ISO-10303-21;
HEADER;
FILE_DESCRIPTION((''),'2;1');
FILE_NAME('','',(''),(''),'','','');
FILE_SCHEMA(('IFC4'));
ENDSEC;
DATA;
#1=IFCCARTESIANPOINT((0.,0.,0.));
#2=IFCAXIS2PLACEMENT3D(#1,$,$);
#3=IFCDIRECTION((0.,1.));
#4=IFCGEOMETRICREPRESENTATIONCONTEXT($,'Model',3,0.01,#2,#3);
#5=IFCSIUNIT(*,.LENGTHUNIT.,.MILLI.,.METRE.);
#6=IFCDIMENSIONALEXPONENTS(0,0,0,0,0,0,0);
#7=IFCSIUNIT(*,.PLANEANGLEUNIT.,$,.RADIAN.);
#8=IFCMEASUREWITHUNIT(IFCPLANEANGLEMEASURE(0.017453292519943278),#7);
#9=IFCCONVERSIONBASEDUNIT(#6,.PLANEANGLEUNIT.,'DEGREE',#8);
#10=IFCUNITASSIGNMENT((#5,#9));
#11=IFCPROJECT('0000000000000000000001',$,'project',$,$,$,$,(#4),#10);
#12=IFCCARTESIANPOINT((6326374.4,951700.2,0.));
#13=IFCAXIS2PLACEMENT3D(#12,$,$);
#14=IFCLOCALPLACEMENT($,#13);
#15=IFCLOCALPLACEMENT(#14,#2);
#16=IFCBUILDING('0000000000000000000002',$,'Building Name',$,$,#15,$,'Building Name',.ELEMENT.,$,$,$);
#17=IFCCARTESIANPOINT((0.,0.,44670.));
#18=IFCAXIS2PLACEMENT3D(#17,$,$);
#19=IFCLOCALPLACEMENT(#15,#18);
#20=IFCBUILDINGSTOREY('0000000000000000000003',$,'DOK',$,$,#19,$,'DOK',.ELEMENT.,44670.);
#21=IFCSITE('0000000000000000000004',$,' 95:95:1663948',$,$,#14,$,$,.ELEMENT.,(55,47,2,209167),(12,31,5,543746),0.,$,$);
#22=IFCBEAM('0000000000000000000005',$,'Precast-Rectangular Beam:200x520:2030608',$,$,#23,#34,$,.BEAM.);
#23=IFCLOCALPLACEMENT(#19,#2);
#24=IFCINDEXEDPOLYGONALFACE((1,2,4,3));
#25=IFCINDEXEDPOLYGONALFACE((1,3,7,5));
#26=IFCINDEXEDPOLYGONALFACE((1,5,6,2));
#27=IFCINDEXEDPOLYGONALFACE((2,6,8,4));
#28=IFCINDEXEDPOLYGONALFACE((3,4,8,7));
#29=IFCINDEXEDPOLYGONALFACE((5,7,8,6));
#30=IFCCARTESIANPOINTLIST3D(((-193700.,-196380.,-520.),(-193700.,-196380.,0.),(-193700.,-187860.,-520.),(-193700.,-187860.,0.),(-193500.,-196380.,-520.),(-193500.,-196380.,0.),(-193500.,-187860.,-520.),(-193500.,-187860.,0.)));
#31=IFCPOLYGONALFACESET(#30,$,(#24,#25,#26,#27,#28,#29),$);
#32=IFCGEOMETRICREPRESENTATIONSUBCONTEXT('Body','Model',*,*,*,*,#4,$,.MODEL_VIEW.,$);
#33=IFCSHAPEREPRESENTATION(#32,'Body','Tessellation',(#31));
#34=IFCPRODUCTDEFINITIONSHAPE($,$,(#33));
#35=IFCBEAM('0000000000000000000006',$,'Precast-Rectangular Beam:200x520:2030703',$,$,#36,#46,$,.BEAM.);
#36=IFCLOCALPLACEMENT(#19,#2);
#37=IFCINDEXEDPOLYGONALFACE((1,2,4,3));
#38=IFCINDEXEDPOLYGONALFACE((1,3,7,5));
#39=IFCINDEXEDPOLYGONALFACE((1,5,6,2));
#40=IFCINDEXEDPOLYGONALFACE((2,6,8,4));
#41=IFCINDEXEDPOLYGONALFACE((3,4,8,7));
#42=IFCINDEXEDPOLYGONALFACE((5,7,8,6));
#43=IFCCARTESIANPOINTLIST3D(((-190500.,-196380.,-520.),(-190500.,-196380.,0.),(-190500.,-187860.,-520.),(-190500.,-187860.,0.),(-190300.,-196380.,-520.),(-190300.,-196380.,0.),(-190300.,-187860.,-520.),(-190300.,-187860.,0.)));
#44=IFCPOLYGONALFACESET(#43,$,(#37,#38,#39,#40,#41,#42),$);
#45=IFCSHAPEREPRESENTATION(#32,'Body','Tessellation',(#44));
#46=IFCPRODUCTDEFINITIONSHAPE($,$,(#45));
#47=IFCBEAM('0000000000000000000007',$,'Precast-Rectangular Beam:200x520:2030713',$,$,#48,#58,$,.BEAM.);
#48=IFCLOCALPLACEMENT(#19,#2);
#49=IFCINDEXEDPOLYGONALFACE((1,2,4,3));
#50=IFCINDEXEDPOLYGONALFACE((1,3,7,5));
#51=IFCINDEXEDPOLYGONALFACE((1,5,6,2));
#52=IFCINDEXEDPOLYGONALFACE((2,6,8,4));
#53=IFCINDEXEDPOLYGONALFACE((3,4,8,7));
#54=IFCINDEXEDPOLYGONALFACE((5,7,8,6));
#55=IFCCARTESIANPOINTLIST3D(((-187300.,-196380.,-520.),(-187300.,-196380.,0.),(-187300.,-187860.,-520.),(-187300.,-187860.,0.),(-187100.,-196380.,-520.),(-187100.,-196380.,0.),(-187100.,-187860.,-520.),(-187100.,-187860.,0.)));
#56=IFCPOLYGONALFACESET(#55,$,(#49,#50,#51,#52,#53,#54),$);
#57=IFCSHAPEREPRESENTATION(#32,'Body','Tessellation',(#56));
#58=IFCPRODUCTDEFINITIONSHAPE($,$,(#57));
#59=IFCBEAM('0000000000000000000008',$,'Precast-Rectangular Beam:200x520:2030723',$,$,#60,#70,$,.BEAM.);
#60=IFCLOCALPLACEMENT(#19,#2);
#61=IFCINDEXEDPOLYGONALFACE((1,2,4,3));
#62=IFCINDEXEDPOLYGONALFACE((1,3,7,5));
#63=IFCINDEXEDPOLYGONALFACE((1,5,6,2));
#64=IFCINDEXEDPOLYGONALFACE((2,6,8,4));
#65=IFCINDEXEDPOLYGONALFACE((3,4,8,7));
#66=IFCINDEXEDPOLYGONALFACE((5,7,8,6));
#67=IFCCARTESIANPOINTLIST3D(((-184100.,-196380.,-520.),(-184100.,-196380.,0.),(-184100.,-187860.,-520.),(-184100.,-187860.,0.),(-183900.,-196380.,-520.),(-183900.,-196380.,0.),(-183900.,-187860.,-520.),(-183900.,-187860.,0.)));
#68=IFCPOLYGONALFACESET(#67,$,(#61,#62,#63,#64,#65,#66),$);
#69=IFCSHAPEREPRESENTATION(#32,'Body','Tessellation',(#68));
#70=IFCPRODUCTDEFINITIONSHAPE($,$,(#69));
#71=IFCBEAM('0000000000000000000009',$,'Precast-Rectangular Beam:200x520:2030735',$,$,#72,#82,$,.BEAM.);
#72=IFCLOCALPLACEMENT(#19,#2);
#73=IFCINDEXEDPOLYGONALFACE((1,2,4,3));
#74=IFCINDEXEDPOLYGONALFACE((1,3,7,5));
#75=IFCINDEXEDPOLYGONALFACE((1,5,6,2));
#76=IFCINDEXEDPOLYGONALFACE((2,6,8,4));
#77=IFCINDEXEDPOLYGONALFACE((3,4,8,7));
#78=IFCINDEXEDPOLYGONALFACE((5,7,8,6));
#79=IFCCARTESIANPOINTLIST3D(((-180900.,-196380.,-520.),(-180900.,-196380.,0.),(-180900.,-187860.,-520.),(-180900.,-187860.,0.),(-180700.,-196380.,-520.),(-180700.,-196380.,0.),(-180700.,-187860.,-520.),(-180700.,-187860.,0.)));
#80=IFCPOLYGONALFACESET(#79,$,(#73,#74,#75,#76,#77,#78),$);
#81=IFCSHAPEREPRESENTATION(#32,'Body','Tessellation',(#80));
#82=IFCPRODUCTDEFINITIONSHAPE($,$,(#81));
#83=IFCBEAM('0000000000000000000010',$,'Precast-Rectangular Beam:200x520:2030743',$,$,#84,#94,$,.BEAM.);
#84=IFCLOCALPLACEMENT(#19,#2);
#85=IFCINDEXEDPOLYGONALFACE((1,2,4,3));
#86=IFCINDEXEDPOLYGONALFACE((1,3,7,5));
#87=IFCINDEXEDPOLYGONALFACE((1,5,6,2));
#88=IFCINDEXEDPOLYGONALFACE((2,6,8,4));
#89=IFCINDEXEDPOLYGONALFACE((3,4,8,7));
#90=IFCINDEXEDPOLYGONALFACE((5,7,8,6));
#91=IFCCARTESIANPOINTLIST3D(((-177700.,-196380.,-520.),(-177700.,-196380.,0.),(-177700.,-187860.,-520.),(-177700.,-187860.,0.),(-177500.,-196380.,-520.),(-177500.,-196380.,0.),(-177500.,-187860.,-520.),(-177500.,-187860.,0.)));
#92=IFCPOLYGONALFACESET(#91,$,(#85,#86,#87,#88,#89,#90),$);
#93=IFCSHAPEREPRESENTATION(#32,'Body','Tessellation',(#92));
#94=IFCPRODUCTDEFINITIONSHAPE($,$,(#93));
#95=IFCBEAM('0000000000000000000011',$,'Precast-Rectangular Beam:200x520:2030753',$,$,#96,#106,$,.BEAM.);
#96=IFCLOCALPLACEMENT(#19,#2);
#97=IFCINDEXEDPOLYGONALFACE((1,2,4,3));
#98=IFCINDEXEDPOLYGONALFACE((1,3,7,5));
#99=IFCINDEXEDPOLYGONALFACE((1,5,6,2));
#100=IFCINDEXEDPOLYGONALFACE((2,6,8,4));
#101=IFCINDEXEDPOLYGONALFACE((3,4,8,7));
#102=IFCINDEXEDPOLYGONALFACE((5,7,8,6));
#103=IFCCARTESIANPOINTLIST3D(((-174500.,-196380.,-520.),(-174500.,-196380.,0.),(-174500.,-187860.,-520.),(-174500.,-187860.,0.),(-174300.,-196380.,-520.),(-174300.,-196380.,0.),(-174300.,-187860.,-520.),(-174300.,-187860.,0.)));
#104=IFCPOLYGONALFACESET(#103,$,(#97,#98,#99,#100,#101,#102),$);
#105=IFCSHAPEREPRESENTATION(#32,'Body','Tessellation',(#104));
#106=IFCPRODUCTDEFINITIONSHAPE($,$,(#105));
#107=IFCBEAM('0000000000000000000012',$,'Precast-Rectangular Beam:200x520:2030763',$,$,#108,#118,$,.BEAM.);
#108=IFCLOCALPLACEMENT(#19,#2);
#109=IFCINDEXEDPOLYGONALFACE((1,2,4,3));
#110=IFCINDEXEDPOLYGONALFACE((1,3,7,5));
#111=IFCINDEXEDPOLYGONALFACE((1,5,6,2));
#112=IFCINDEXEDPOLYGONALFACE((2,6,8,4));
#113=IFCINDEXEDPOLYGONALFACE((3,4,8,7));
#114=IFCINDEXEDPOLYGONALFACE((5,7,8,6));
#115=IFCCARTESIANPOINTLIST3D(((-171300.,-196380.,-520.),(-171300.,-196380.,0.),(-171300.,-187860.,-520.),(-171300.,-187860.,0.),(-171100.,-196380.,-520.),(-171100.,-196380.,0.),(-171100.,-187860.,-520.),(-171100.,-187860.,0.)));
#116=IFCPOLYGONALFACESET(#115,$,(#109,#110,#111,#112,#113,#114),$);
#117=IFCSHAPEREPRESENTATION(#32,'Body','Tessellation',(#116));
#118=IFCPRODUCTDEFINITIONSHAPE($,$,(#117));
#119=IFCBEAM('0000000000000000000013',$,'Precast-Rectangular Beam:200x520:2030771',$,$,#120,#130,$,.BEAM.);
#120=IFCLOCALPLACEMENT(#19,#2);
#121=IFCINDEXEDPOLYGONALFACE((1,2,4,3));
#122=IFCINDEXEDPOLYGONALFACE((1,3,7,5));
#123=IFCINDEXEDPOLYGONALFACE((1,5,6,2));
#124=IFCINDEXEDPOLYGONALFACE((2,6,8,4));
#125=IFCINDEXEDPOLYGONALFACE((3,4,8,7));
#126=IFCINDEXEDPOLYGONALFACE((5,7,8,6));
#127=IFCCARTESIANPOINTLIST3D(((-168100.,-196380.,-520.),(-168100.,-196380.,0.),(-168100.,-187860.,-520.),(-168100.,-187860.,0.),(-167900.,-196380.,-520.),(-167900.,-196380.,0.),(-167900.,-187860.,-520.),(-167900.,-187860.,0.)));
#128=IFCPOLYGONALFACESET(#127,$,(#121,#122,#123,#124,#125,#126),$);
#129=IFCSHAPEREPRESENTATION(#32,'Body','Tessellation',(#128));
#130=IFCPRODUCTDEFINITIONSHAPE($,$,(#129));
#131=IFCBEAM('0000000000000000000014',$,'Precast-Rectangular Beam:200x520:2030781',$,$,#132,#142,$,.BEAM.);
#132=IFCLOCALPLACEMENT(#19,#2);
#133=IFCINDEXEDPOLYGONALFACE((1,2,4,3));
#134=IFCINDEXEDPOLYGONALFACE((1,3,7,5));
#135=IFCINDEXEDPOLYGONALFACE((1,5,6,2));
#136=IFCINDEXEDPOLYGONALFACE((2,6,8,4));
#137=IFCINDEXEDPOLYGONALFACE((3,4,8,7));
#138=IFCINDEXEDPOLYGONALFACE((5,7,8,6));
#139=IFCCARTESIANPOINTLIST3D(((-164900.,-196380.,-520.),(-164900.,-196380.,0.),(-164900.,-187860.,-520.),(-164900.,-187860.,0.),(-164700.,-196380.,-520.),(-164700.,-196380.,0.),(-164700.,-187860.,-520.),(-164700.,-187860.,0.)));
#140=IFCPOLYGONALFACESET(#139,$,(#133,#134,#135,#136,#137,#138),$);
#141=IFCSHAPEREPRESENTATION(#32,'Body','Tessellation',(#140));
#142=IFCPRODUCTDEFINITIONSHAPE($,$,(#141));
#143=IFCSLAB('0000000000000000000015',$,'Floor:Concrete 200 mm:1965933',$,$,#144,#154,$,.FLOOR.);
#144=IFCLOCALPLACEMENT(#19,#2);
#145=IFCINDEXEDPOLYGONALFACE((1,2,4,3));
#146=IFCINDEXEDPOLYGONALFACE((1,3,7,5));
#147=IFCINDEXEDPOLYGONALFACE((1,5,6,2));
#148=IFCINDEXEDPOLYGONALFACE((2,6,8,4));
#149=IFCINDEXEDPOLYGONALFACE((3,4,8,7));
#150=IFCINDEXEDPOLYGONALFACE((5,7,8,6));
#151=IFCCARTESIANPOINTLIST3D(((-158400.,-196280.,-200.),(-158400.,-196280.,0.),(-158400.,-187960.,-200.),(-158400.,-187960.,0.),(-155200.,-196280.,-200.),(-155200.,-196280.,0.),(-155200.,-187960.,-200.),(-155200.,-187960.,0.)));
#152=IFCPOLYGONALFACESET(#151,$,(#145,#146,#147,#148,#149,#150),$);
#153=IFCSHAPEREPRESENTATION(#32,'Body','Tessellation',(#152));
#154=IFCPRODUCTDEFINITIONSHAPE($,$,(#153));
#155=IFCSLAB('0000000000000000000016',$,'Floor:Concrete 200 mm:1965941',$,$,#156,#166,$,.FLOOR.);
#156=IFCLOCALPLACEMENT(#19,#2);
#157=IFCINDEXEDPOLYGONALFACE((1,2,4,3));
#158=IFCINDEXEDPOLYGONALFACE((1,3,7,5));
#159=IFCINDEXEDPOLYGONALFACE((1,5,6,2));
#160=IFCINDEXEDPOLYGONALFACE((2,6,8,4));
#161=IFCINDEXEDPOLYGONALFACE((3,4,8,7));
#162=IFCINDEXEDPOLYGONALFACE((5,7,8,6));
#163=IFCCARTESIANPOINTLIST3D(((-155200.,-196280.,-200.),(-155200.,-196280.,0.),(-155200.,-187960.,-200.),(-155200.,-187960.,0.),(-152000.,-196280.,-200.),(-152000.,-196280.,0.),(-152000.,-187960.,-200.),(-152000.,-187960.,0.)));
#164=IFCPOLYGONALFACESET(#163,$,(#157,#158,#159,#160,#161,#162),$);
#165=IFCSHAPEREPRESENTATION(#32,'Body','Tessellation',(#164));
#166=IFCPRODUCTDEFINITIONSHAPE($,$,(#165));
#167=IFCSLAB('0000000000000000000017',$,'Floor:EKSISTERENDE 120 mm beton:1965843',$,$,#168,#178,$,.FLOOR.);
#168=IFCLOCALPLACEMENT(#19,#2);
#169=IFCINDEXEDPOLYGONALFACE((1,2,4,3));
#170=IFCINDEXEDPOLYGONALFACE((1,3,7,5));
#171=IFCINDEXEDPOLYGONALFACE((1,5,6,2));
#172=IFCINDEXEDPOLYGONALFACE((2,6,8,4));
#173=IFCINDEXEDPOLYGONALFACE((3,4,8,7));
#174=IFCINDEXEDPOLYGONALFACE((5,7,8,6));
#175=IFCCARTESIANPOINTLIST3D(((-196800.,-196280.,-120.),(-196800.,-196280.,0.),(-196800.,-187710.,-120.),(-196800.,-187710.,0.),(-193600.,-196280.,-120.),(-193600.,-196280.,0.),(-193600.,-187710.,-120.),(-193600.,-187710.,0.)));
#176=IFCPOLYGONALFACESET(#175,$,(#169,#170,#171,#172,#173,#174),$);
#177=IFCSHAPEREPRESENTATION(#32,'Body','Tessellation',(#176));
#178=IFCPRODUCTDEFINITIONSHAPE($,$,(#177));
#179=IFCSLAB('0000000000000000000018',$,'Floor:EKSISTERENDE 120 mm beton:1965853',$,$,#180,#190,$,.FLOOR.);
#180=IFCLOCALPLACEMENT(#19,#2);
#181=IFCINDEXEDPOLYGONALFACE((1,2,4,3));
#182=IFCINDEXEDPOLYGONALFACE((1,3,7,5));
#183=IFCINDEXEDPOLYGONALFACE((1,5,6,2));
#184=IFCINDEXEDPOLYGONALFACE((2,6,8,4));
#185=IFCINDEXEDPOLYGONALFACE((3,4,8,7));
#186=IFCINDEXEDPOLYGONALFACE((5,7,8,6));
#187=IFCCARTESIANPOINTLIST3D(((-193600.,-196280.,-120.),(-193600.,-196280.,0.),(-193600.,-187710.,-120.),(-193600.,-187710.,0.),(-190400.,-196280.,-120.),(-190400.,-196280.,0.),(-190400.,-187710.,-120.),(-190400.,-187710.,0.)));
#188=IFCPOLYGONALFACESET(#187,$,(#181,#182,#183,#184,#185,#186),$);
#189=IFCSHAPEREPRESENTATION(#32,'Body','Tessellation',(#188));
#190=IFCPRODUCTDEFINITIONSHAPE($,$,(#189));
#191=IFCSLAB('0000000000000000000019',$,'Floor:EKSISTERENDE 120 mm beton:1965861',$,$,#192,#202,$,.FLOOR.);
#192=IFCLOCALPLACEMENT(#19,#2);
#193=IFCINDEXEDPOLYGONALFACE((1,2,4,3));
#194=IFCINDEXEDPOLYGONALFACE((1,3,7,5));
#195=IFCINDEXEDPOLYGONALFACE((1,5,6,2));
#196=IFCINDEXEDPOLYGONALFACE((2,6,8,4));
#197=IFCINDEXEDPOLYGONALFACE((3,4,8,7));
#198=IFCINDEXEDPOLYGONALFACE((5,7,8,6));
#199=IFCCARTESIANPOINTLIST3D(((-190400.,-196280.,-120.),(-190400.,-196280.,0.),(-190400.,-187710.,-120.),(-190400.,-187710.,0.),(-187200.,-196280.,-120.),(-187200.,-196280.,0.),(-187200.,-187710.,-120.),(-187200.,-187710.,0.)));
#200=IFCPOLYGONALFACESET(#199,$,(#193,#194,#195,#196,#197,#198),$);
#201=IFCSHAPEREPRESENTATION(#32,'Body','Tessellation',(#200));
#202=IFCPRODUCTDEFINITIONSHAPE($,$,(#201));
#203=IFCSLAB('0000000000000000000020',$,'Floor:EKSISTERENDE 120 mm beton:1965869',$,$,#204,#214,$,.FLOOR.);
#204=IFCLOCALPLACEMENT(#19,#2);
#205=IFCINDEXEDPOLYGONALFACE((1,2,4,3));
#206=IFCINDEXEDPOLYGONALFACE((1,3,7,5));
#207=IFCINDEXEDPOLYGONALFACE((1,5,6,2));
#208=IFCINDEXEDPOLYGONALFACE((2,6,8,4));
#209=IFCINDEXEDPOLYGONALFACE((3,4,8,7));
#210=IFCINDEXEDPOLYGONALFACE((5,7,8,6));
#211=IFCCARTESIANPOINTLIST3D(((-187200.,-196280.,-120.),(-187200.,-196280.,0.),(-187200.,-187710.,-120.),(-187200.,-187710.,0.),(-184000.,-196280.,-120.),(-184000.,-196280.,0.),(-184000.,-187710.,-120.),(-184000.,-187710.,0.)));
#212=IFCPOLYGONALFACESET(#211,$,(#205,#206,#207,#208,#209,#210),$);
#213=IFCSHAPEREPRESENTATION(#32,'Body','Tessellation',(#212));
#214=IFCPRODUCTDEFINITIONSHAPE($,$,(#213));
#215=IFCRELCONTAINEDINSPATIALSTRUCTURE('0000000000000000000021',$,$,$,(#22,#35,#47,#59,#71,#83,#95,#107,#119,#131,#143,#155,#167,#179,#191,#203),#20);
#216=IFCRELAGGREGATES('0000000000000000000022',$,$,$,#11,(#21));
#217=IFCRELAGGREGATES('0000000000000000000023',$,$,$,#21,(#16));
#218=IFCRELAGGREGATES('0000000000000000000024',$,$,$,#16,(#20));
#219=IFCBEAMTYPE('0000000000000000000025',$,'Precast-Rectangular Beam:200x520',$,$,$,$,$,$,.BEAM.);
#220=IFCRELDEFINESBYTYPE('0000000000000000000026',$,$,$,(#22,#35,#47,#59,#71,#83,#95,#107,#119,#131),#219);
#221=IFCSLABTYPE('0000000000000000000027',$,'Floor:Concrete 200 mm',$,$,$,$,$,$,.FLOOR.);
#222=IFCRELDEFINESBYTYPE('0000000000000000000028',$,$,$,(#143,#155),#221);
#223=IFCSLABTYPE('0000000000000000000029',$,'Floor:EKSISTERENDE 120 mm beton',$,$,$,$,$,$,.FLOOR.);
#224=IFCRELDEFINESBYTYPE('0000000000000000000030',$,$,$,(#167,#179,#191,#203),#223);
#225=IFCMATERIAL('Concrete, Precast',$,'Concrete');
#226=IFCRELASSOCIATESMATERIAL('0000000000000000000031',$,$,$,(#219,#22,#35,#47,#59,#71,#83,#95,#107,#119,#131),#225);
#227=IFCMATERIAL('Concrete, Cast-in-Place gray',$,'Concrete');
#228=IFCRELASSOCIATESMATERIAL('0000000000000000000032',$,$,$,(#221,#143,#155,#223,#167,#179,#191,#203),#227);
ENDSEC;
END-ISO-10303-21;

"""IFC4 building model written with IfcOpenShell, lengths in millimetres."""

from ifc_helpers import new_model, entity, si_unit, converted_unit, direction, frame, origin, place, context, subcontext, project, spatial, indexed_curve, outline, extrude, source, transform, mapped, material, type_object, type_shapes, element, save


model = new_model("IFC4")

# Units and contexts
model_context = context("Model", 3, precision=0.01, world=origin(), true_north=direction((0.0, 1.0)))
body_context = subcontext(model_context, "Body", "Model", "MODEL_VIEW")
ifc_project = project(units=[si_unit("LENGTHUNIT", "METRE", prefix="MILLI"), converted_unit("PLANEANGLEUNIT", "DEGREE", entity("IfcPlaneAngleMeasure", 0.017453292519943278), si_unit("PLANEANGLEUNIT", "RADIAN"), dimensions=[0, 0, 0, 0, 0, 0, 0])], contexts=[model_context])

# Site, building, storey
site_placement = place(None, frame((6326374.4, 951700.2, 0.0)))
site = spatial("IfcSite", under=ifc_project, at=site_placement, Name=" 95:95:1663948", CompositionType="ELEMENT", RefLatitude=(55, 47, 2, 209167), RefLongitude=(12, 31, 5, 543746), RefElevation=0.0)
building_placement = place(site_placement, origin())
building = spatial("IfcBuilding", under=site, at=building_placement, Name="Building Name", LongName="Building Name", CompositionType="ELEMENT")
storey_placement = place(building_placement, frame((0.0, 0.0, 44670.0)))
storey = spatial("IfcBuildingStorey", under=building, at=storey_placement, Name="DOK", LongName="DOK", CompositionType="ELEMENT", Elevation=44670.0)

# Beams
ifc_material_1 = material(Name="Concrete, Precast", Category="Concrete")
beam_type = type_object("IfcBeamType", Name="Precast-Rectangular Beam:200x520", PredefinedType="BEAM", material=ifc_material_1)
shared_shape = source(origin(), body_context, "Body", "SweptSolid", [
    extrude(outline(indexed_curve([(-4260.0, -100.0), (4260.0, -100.0), (4260.0, 100.0), (-4260.0, 100.0), (-4260.0, -100.0)], self_intersect=False)), frame((3.6, 0.0, -260.0), z_axis=(0.0, 0.0, 1.0), x_axis=(-1.0, 0.0, 0.0)), (0.0, 0.0, 1.0), 520.0),
])
type_shapes(beam_type, [shared_shape])
for number, where, z_axis, x_axis, name in (
    (1, (-193600.0, -192116.4, -260.0), (0.0, 0.0, 1.0), (0.0, -1.0, 0.0), "Precast-Rectangular Beam:200x520:2030608"),
    (2, (-190400.0, -192116.4, -260.0), (0.0, 0.0, 1.0), (0.0, -1.0, 0.0), "Precast-Rectangular Beam:200x520:2030703"),
    (3, (-187200.0, -192116.4, -260.0), (0.0, 0.0, 1.0), (0.0, -1.0, 0.0), "Precast-Rectangular Beam:200x520:2030713"),
    (4, (-184000.0, -192116.4, -260.0), (0.0, 0.0, 1.0), (0.0, -1.0, 0.0), "Precast-Rectangular Beam:200x520:2030723"),
    (5, (-180800.0, -192116.4, -260.0), (0.0, 0.0, 1.0), (0.0, -1.0, 0.0), "Precast-Rectangular Beam:200x520:2030735"),
    (6, (-177600.0, -192116.4, -260.0), (0.0, 0.0, 1.0), (0.0, -1.0, 0.0), "Precast-Rectangular Beam:200x520:2030743"),
    (7, (-174400.0, -192116.4, -260.0), (0.0, 0.0, 1.0), (0.0, -1.0, 0.0), "Precast-Rectangular Beam:200x520:2030753"),
    (8, (-171200.0, -192116.4, -260.0), (0.0, 0.0, 1.0), (0.0, -1.0, 0.0), "Precast-Rectangular Beam:200x520:2030763"),
    (9, (-168000.0, -192116.4, -260.0), (0.0, 0.0, 1.0), (0.0, -1.0, 0.0), "Precast-Rectangular Beam:200x520:2030771"),
    (10, (-164800.0, -192116.4, -260.0), (0.0, 0.0, 1.0), (0.0, -1.0, 0.0), "Precast-Rectangular Beam:200x520:2030781"),
):
    element("IfcBeam", number, at=place(storey_placement, frame(where, z_axis=z_axis, x_axis=x_axis)), inside=storey, type_object=beam_type, material=ifc_material_1, Name=name, PredefinedType="BEAM", context=body_context, shape_type="MappedRepresentation", body=[
        mapped(shared_shape, transform((0.0, 0.0, 0.0), scale=1.0)),
    ])

# Slabs
ifc_material_2 = material(Name="Concrete, Cast-in-Place gray", Category="Concrete")
slab_type_1 = type_object("IfcSlabType", Name="Floor:Concrete 200 mm", PredefinedType="FLOOR", material=ifc_material_2)
slab_1_placement = place(storey_placement, origin())
element("IfcSlab", 11, at=slab_1_placement, inside=storey, type_object=slab_type_1, material=ifc_material_2, Name="Floor:Concrete 200 mm:1965933", PredefinedType="FLOOR", context=body_context, shape_type="SweptSolid", body=[
    extrude(outline(indexed_curve([(-4160.0, -1600.0), (4160.0, -1600.0), (4160.0, 1600.0), (-4160.0, 1600.0), (-4160.0, -1600.0)], self_intersect=False)), frame((-156800.0, -192120.0, 0.0), z_axis=(0.0, 0.0, -1.0), x_axis=(0.0, 1.0, 0.0)), (0.0, 0.0, 1.0), 200.0),
])
slab_2_placement = place(storey_placement, origin())
element("IfcSlab", 12, at=slab_2_placement, inside=storey, type_object=slab_type_1, material=ifc_material_2, Name="Floor:Concrete 200 mm:1965941", PredefinedType="FLOOR", context=body_context, shape_type="SweptSolid", body=[
    extrude(outline(indexed_curve([(-4160.0, -1600.0), (4160.0, -1600.0), (4160.0, 1600.0), (-4160.0, 1600.0), (-4160.0, -1600.0)], self_intersect=False)), frame((-153600.0, -192120.0, 0.0), z_axis=(0.0, 0.0, -1.0), x_axis=(0.0, 1.0, 0.0)), (0.0, 0.0, 1.0), 200.0),
])
slab_type_2 = type_object("IfcSlabType", Name="Floor:EKSISTERENDE 120 mm beton", PredefinedType="FLOOR", material=ifc_material_2)
slab_3_placement = place(storey_placement, origin())
element("IfcSlab", 13, at=slab_3_placement, inside=storey, type_object=slab_type_2, material=ifc_material_2, Name="Floor:EKSISTERENDE 120 mm beton:1965843", PredefinedType="FLOOR", context=body_context, shape_type="SweptSolid", body=[
    extrude(outline(indexed_curve([(-4285.0, -1600.0), (4285.0, -1600.0), (4285.0, 1600.0), (-4285.0, 1600.0), (-4285.0, -1600.0)], self_intersect=False)), frame((-195200.0, -191995.0, 0.0), z_axis=(0.0, 0.0, -1.0), x_axis=(0.0, 1.0, 0.0)), (0.0, 0.0, 1.0), 120.0),
])
slab_4_placement = place(storey_placement, origin())
element("IfcSlab", 14, at=slab_4_placement, inside=storey, type_object=slab_type_2, material=ifc_material_2, Name="Floor:EKSISTERENDE 120 mm beton:1965853", PredefinedType="FLOOR", context=body_context, shape_type="SweptSolid", body=[
    extrude(outline(indexed_curve([(-4285.0, -1600.0), (4285.0, -1600.0), (4285.0, 1600.0), (-4285.0, 1600.0), (-4285.0, -1600.0)], self_intersect=False)), frame((-192000.0, -191995.0, 0.0), z_axis=(0.0, 0.0, -1.0), x_axis=(0.0, 1.0, 0.0)), (0.0, 0.0, 1.0), 120.0),
])
slab_5_placement = place(storey_placement, origin())
element("IfcSlab", 15, at=slab_5_placement, inside=storey, type_object=slab_type_2, material=ifc_material_2, Name="Floor:EKSISTERENDE 120 mm beton:1965861", PredefinedType="FLOOR", context=body_context, shape_type="SweptSolid", body=[
    extrude(outline(indexed_curve([(-4285.0, -1600.0), (4285.0, -1600.0), (4285.0, 1600.0), (-4285.0, 1600.0), (-4285.0, -1600.0)], self_intersect=False)), frame((-188800.0, -191995.0, 0.0), z_axis=(0.0, 0.0, -1.0), x_axis=(0.0, 1.0, 0.0)), (0.0, 0.0, 1.0), 120.0),
])
slab_6_placement = place(storey_placement, origin())
element("IfcSlab", 16, at=slab_6_placement, inside=storey, type_object=slab_type_2, material=ifc_material_2, Name="Floor:EKSISTERENDE 120 mm beton:1965869", PredefinedType="FLOOR", context=body_context, shape_type="SweptSolid", body=[
    extrude(outline(indexed_curve([(-4285.0, -1600.0), (4285.0, -1600.0), (4285.0, 1600.0), (-4285.0, 1600.0), (-4285.0, -1600.0)], self_intersect=False)), frame((-185600.0, -191995.0, 0.0), z_axis=(0.0, 0.0, -1.0), x_axis=(0.0, 1.0, 0.0)), (0.0, 0.0, 1.0), 120.0),
])

save(model, "model.ifc")
